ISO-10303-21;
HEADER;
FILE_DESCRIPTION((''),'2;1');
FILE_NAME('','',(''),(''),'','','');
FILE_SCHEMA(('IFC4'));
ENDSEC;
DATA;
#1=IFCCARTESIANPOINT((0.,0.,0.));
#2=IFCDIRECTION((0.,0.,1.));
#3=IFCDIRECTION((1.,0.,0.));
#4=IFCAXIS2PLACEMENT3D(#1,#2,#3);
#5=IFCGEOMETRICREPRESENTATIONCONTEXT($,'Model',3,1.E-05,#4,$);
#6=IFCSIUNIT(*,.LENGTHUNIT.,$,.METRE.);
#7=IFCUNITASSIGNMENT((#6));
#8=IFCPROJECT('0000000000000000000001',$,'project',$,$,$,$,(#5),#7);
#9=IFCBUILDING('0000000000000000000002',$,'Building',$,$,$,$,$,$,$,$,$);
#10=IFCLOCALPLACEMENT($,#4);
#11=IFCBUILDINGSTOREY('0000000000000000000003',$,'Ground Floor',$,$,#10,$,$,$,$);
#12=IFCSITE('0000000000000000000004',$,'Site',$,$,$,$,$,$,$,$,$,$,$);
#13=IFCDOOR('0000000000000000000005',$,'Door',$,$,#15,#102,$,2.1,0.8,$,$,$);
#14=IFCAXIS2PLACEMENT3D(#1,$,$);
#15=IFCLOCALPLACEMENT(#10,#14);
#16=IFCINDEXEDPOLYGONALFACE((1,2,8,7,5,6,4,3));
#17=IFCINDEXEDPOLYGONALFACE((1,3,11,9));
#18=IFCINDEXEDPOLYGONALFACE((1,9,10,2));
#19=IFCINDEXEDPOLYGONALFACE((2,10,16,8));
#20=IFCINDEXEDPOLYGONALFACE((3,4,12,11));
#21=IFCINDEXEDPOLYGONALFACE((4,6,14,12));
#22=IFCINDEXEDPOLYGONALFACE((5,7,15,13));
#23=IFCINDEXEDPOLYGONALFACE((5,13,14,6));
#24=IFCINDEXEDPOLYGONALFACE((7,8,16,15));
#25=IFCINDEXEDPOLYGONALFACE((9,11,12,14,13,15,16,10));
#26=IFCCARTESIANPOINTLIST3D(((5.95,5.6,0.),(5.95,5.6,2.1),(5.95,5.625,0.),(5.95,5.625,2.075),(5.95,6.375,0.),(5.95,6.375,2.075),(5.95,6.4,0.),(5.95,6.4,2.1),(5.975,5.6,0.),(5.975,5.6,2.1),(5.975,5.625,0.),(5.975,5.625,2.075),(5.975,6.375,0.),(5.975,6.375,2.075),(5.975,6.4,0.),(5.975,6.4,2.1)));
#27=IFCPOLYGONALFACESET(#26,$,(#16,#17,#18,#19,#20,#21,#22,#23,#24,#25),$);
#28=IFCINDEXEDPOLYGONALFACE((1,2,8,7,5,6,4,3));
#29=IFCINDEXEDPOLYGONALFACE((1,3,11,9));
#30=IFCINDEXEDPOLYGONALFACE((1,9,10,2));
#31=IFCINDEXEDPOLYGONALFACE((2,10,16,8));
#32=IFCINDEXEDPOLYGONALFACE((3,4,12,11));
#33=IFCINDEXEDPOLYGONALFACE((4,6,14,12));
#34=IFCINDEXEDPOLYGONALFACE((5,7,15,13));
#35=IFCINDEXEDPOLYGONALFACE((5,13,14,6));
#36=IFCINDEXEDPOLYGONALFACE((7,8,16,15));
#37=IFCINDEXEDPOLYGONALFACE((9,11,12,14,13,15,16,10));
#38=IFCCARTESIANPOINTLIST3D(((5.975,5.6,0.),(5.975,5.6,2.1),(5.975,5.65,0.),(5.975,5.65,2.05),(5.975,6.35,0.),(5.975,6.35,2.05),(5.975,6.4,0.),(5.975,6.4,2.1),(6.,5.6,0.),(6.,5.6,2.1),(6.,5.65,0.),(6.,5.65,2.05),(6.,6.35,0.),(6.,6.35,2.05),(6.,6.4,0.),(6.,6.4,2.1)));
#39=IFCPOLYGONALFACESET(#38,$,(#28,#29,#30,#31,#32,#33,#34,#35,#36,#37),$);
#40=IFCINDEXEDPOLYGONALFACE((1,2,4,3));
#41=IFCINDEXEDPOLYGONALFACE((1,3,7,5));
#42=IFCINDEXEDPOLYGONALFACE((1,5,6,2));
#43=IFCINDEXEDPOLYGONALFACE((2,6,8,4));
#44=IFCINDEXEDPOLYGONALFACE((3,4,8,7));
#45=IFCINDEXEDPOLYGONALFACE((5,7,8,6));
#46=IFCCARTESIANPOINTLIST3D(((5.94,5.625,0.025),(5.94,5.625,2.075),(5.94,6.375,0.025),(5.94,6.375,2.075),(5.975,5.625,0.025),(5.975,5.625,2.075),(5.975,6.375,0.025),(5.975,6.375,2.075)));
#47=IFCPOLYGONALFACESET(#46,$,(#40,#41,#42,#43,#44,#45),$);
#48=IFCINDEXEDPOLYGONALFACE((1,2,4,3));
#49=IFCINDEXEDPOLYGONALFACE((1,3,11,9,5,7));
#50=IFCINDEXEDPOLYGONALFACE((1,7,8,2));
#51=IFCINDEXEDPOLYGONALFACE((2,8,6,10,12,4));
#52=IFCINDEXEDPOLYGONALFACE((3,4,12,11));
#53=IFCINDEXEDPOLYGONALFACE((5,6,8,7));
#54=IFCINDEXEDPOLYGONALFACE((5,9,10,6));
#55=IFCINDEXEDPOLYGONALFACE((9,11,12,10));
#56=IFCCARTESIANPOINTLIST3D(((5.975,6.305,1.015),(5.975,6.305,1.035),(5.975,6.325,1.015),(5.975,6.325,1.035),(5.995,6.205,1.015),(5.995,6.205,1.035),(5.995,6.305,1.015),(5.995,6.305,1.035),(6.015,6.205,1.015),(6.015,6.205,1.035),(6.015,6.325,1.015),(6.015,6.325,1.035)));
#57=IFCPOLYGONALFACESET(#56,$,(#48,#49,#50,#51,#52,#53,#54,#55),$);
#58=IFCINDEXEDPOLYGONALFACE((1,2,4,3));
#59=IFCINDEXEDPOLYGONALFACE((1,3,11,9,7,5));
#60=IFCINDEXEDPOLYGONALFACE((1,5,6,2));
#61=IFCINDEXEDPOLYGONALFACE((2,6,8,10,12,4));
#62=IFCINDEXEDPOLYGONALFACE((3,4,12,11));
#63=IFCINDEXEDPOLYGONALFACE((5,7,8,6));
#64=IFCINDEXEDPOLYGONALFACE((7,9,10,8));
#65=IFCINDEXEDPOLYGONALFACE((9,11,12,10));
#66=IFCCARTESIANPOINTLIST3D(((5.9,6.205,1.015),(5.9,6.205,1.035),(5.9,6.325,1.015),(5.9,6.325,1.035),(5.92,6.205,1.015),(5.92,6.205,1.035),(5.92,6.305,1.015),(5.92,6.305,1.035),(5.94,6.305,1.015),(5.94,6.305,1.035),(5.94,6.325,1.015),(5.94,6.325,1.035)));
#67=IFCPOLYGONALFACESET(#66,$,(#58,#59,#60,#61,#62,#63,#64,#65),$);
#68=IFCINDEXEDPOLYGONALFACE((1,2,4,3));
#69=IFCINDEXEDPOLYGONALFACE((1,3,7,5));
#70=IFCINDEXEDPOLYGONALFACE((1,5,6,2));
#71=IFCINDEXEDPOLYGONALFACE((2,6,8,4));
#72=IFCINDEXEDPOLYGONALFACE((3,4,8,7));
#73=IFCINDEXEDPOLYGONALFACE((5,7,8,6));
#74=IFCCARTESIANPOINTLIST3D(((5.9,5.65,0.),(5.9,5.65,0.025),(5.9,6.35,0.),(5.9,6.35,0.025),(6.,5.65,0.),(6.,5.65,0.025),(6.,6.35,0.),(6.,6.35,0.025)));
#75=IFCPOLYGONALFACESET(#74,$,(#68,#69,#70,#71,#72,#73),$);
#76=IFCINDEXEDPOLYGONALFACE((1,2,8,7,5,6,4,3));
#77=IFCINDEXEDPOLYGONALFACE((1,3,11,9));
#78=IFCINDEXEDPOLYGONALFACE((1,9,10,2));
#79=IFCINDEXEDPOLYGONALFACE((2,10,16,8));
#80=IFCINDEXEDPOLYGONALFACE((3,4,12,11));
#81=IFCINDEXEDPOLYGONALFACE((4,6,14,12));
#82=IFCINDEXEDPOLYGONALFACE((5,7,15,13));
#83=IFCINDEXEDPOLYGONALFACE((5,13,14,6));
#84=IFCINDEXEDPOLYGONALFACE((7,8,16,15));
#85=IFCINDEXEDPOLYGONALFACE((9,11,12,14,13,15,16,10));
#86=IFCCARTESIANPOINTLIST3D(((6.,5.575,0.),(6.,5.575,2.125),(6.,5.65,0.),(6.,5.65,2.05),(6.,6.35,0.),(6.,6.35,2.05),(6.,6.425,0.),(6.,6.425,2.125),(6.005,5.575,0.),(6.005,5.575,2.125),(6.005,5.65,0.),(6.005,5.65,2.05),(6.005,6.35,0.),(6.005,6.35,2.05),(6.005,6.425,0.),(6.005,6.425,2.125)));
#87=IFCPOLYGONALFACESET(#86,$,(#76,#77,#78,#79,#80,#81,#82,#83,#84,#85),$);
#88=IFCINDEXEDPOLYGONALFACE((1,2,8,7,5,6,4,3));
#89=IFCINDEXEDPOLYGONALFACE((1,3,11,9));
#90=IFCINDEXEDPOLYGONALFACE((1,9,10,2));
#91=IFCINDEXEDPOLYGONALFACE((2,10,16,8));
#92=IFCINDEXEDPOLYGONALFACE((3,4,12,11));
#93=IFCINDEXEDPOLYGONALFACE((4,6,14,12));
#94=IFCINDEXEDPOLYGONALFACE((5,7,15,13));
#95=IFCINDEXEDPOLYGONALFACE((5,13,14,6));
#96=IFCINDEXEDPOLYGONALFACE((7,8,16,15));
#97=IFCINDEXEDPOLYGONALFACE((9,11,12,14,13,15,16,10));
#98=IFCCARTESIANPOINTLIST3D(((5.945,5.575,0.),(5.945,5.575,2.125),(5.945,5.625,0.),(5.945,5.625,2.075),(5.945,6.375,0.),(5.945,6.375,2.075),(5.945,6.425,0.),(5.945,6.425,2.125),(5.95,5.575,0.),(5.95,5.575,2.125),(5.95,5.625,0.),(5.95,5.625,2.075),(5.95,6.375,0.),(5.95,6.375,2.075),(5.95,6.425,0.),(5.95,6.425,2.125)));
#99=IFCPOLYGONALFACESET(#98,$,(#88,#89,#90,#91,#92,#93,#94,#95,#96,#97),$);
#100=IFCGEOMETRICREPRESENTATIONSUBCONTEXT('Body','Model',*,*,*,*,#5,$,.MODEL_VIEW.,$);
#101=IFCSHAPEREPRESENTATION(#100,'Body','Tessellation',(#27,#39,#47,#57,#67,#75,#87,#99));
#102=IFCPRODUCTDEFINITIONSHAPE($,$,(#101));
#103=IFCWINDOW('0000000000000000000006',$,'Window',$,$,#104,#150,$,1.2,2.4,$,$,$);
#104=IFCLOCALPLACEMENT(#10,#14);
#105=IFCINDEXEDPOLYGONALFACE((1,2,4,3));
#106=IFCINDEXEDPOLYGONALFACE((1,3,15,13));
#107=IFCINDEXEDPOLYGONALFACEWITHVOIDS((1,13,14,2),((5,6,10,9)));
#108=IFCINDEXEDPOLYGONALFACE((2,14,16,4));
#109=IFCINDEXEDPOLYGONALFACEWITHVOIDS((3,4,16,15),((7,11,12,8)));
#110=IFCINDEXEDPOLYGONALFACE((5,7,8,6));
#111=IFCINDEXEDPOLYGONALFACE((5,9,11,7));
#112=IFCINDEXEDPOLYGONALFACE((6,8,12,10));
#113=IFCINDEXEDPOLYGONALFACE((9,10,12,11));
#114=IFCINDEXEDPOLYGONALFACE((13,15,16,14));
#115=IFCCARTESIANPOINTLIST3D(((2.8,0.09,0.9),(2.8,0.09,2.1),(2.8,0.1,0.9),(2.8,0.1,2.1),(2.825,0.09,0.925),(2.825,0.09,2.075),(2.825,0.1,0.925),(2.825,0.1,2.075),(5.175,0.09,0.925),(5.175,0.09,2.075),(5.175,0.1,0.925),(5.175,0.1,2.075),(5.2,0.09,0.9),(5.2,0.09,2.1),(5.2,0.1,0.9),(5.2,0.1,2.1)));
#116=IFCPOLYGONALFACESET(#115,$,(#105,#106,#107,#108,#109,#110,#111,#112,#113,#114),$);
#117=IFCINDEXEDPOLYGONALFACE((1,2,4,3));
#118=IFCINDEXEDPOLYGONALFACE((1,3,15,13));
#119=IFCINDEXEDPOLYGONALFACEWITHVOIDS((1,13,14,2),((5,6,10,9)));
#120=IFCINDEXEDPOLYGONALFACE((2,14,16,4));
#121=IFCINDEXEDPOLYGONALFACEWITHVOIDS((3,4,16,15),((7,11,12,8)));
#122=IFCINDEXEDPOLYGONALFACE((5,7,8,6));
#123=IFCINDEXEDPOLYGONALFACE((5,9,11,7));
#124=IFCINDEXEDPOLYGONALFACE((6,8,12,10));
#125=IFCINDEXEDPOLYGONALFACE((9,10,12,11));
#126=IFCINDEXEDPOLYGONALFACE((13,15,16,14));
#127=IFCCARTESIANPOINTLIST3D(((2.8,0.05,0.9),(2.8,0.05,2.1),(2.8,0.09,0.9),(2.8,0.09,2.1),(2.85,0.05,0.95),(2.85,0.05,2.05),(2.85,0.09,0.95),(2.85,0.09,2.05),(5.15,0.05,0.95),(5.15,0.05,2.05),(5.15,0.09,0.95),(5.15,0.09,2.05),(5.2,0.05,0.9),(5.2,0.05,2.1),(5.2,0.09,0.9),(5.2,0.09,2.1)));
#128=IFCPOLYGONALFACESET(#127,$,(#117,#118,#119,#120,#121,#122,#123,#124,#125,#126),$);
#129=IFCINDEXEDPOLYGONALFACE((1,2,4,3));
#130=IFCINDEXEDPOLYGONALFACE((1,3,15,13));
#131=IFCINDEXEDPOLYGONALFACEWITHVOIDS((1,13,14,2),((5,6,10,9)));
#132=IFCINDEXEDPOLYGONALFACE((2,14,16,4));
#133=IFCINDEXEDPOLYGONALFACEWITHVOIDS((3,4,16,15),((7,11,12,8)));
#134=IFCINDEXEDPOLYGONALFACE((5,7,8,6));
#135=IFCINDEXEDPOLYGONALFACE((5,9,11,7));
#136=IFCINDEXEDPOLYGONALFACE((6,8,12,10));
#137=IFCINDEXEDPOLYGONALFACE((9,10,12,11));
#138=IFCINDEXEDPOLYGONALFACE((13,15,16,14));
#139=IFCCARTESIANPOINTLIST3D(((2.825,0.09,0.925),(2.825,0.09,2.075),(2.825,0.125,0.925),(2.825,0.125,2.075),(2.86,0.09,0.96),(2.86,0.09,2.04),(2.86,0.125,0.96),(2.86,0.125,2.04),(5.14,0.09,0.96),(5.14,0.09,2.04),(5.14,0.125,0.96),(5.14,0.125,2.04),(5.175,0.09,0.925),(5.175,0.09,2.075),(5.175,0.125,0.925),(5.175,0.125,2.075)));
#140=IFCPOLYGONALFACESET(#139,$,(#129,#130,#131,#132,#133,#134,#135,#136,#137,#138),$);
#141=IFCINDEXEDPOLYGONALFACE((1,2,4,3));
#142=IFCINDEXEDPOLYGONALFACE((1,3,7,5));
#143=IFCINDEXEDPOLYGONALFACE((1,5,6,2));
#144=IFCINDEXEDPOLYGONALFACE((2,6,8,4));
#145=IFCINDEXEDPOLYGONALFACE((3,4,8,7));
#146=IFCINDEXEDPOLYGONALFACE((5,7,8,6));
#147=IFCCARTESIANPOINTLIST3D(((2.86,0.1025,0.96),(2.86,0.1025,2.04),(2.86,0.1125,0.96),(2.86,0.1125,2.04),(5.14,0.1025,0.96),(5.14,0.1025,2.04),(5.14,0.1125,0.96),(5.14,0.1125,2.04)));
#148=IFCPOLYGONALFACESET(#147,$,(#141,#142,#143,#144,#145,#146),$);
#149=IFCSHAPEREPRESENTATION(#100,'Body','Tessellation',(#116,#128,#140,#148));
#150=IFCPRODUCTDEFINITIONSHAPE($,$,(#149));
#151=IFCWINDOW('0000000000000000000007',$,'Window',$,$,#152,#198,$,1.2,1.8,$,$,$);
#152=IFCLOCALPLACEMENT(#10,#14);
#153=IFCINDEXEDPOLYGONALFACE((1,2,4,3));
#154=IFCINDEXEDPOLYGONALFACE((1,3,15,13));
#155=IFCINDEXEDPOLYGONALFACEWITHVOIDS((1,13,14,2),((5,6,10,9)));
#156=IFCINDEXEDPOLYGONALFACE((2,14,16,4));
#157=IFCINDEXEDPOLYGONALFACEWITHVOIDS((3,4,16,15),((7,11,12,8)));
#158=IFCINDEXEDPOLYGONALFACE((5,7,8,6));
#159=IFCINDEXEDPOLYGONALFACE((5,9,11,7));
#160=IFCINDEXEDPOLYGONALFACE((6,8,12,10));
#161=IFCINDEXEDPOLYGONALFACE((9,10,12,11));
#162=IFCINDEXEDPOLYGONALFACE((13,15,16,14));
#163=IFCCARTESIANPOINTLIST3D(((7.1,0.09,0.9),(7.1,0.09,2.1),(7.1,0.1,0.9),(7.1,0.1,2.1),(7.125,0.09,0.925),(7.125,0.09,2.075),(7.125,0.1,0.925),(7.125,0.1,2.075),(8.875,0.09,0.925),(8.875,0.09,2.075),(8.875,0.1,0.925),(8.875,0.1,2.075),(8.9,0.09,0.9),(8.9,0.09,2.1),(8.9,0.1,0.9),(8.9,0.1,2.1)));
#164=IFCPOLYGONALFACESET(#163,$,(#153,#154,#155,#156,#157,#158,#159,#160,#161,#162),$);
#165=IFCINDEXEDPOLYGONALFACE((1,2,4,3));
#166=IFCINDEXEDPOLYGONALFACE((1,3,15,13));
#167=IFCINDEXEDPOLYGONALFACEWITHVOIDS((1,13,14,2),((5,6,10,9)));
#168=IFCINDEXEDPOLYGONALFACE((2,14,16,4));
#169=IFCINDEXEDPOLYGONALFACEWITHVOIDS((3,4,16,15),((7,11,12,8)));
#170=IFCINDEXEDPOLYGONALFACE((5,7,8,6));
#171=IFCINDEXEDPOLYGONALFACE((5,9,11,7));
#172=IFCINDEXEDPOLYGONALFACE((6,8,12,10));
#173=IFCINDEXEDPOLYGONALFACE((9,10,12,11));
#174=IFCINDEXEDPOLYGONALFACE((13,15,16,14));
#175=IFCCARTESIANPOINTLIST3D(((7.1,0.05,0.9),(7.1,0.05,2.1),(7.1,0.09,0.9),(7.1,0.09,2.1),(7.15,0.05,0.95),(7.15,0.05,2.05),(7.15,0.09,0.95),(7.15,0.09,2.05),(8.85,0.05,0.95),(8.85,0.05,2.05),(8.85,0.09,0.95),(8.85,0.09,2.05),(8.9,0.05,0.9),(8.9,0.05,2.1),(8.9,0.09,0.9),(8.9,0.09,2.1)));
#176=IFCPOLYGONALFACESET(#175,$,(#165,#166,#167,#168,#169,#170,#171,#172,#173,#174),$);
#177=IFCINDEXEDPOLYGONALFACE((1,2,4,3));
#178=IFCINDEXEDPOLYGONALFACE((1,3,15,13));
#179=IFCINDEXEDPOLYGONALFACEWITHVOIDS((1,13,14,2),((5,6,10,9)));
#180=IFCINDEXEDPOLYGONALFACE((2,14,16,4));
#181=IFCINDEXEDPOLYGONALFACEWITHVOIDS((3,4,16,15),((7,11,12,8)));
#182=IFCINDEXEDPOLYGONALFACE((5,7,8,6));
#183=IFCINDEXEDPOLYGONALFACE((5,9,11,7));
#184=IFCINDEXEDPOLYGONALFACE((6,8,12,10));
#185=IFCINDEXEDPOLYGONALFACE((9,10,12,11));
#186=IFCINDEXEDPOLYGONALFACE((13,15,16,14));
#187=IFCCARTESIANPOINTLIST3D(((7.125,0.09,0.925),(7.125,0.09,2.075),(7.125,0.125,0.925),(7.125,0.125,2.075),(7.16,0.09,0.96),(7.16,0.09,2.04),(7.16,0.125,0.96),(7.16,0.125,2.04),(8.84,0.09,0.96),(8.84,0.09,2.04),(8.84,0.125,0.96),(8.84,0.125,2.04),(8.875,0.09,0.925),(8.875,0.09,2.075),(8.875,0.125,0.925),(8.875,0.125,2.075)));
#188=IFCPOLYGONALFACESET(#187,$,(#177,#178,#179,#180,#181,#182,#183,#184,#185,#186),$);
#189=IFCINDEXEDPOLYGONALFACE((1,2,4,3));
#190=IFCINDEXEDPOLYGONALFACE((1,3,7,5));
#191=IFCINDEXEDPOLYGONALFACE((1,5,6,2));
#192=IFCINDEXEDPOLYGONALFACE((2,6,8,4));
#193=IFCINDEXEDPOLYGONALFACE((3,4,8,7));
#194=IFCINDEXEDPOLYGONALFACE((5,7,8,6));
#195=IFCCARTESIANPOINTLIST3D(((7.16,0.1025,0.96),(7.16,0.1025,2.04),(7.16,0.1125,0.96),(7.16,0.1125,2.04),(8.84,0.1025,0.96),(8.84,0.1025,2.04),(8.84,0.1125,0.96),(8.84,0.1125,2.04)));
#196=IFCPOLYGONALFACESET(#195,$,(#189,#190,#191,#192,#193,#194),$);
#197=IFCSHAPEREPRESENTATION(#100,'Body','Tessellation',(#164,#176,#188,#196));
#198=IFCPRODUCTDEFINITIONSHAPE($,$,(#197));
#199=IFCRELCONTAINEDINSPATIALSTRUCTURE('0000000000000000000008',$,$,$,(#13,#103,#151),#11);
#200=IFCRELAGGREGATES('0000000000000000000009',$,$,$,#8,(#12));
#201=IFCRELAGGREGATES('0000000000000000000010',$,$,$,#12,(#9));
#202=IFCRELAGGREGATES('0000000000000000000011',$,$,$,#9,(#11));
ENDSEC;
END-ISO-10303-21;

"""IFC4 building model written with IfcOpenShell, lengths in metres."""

from ifc_helpers import new_model, si_unit, frame, origin_with_axes, place, context, subcontext, project, spatial, line, indexed_curve, outline, extrude, element, save


model = new_model("IFC4")

# Units and contexts
model_context = context("Model", 3, precision=1e-05, world=origin_with_axes())
body_context = subcontext(model_context, "Body", "Model", "MODEL_VIEW")
ifc_project = project(units=[si_unit("LENGTHUNIT", "METRE")], contexts=[model_context])

# Site, building, storey
site = spatial("IfcSite", under=ifc_project, Name="Site")
building = spatial("IfcBuilding", under=site, Name="Building")
storey_placement = place(None, origin_with_axes())
storey = spatial("IfcBuildingStorey", under=building, at=storey_placement, Name="Ground Floor")

# Door
door_1_placement = place(storey_placement, frame((6.0, 5.6, 0.0), z_axis=(0.0, 0.0, 1.0), x_axis=(0.0, 1.0, 0.0)))
element("IfcDoor", 1, at=door_1_placement, inside=storey, Name="Door", OverallHeight=2.1, OverallWidth=0.8, context=body_context, shape_type="SweptSolid", body=[
    extrude(outline(indexed_curve([(0.0, 0.0), (0.0, 2.1), (0.8, 2.1), (0.8, 0.0), (0.775, 0.0), (0.775, 2.075), (0.025, 2.075), (0.025, 0.0)], segments=[line(1, 2, 3, 4, 5, 6, 7, 8, 1)])), frame((0.0, 0.025, 0.0), z_axis=(0.0, -1.0, 0.0), x_axis=(1.0, 0.0, 0.0)), (0.0, 0.0, -1.0), 0.025),
    extrude(outline(indexed_curve([(0.0, 0.0), (0.0, 2.1), (0.8, 2.1), (0.8, 0.0), (0.75, 0.0), (0.75, 2.05), (0.05, 2.05), (0.05, 0.0)], segments=[line(1, 2, 3, 4, 5, 6, 7, 8, 1)])), frame((0.0, 0.0, 0.0), z_axis=(0.0, -1.0, 0.0), x_axis=(1.0, 0.0, 0.0)), (0.0, 0.0, -1.0), 0.025),
    extrude(outline(indexed_curve([(0.0, 0.0), (0.75, 0.0), (0.75, 0.035), (0.0, 0.035)], segments=[line(1, 2, 3, 4, 1)])), frame((0.025, 0.025, 0.025), z_axis=(0.0, 0.0, 1.0), x_axis=(1.0, 0.0, 0.0)), (0.0, 0.0, 1.0), 2.05),
    extrude(outline(indexed_curve([(0.0, 0.0), (0.0, -0.04), (-0.12, -0.04), (-0.12, -0.02), (-0.02, -0.02), (-0.02, 0.0)], segments=[line(1, 2, 3, 4, 5, 6, 1)])), frame((0.725, 0.025, 1.015), z_axis=(0.0, 0.0, 1.0), x_axis=(1.0, 0.0, 0.0)), (0.0, 0.0, 1.0), 0.02),
    extrude(outline(indexed_curve([(0.0, 0.0), (0.0, 0.04), (-0.12, 0.04), (-0.12, 0.02), (-0.02, 0.02), (-0.02, 0.0)], segments=[line(1, 2, 3, 4, 5, 6, 1)])), frame((0.725, 0.06, 1.015), z_axis=(0.0, 0.0, 1.0), x_axis=(1.0, 0.0, 0.0)), (0.0, 0.0, 1.0), 0.02),
    extrude(outline(indexed_curve([(0.0, 0.0), (0.7, 0.0), (0.7, 0.1), (0.0, 0.1)], segments=[line(1, 2, 3, 4, 1)])), frame((0.05, 0.0, 0.0), z_axis=(0.0, 0.0, 1.0), x_axis=(1.0, 0.0, 0.0)), (0.0, 0.0, 1.0), 0.025),
    extrude(outline(indexed_curve([(0.0, 0.0), (0.0, 2.125), (0.85, 2.125), (0.85, 0.0), (0.775, 0.0), (0.775, 2.05), (0.075, 2.05), (0.075, 0.0)], segments=[line(1, 2, 3, 4, 5, 6, 7, 8, 1)])), frame((-0.025, -0.005, 0.0), z_axis=(0.0, -1.0, 0.0), x_axis=(1.0, 0.0, 0.0)), (0.0, 0.0, -1.0), 0.005),
    extrude(outline(indexed_curve([(0.0, 0.0), (0.0, 2.125), (0.85, 2.125), (0.85, 0.0), (0.8, 0.0), (0.8, 2.075), (0.05, 2.075), (0.05, 0.0)], segments=[line(1, 2, 3, 4, 5, 6, 7, 8, 1)])), frame((-0.025, 0.05, 0.0), z_axis=(0.0, -1.0, 0.0), x_axis=(1.0, 0.0, 0.0)), (0.0, 0.0, -1.0), 0.005),
])

# Windows
window_1_placement = place(storey_placement, frame((2.8, 0.0, 0.9), z_axis=(0.0, 0.0, 1.0), x_axis=(1.0, 0.0, 0.0)))
element("IfcWindow", 2, at=window_1_placement, inside=storey, Name="Window", OverallHeight=1.2, OverallWidth=2.4, context=body_context, shape_type="SweptSolid", body=[
    extrude(outline(indexed_curve([(0.0, 0.0), (2.4, 0.0), (2.4, 1.2), (0.0, 1.2)], segments=[line(1, 2, 3, 4, 1)]), holes=[indexed_curve([(0.025, 0.025), (2.375, 0.025), (2.375, 1.175), (0.025, 1.175)], segments=[line(1, 2, 3, 4, 1)])]), frame((0.0, 0.09, 0.0), z_axis=(0.0, -1.0, 0.0), x_axis=(1.0, 0.0, 0.0)), (0.0, 0.0, -1.0), 0.01),
    extrude(outline(indexed_curve([(0.0, 0.0), (2.4, 0.0), (2.4, 1.2), (0.0, 1.2)], segments=[line(1, 2, 3, 4, 1)]), holes=[indexed_curve([(0.05, 0.05), (2.35, 0.05), (2.35, 1.15), (0.05, 1.15)], segments=[line(1, 2, 3, 4, 1)])]), frame((0.0, 0.05, 0.0), z_axis=(0.0, -1.0, 0.0), x_axis=(1.0, 0.0, 0.0)), (0.0, 0.0, -1.0), 0.04),
    extrude(outline(indexed_curve([(0.0, 0.0), (2.35, 0.0), (2.35, 1.15), (0.0, 1.15)], segments=[line(1, 2, 3, 4, 1)]), holes=[indexed_curve([(0.035, 0.035), (2.315, 0.035), (2.315, 1.115), (0.035, 1.115)], segments=[line(1, 2, 3, 4, 1)])]), frame((0.025, 0.09, 0.025), z_axis=(0.0, -1.0, 0.0), x_axis=(1.0, 0.0, 0.0)), (0.0, 0.0, -1.0), 0.035),
    extrude(outline(indexed_curve([(0.035, 0.035), (2.315, 0.035), (2.315, 1.115), (0.035, 1.115)], segments=[line(1, 2, 3, 4, 1)])), frame((0.025, 0.1025, 0.025), z_axis=(0.0, -1.0, 0.0), x_axis=(1.0, 0.0, 0.0)), (0.0, 0.0, -1.0), 0.01),
])
window_2_placement = place(storey_placement, frame((7.1, 0.0, 0.9), z_axis=(0.0, 0.0, 1.0), x_axis=(1.0, 0.0, 0.0)))
element("IfcWindow", 3, at=window_2_placement, inside=storey, Name="Window", OverallHeight=1.2, OverallWidth=1.8, context=body_context, shape_type="SweptSolid", body=[
    extrude(outline(indexed_curve([(0.0, 0.0), (1.8, 0.0), (1.8, 1.2), (0.0, 1.2)], segments=[line(1, 2, 3, 4, 1)]), holes=[indexed_curve([(0.025, 0.025), (1.775, 0.025), (1.775, 1.175), (0.025, 1.175)], segments=[line(1, 2, 3, 4, 1)])]), frame((0.0, 0.09, 0.0), z_axis=(0.0, -1.0, 0.0), x_axis=(1.0, 0.0, 0.0)), (0.0, 0.0, -1.0), 0.01),
    extrude(outline(indexed_curve([(0.0, 0.0), (1.8, 0.0), (1.8, 1.2), (0.0, 1.2)], segments=[line(1, 2, 3, 4, 1)]), holes=[indexed_curve([(0.05, 0.05), (1.75, 0.05), (1.75, 1.15), (0.05, 1.15)], segments=[line(1, 2, 3, 4, 1)])]), frame((0.0, 0.05, 0.0), z_axis=(0.0, -1.0, 0.0), x_axis=(1.0, 0.0, 0.0)), (0.0, 0.0, -1.0), 0.04),
    extrude(outline(indexed_curve([(0.0, 0.0), (1.75, 0.0), (1.75, 1.15), (0.0, 1.15)], segments=[line(1, 2, 3, 4, 1)]), holes=[indexed_curve([(0.035, 0.035), (1.715, 0.035), (1.715, 1.115), (0.035, 1.115)], segments=[line(1, 2, 3, 4, 1)])]), frame((0.025, 0.09, 0.025), z_axis=(0.0, -1.0, 0.0), x_axis=(1.0, 0.0, 0.0)), (0.0, 0.0, -1.0), 0.035),
    extrude(outline(indexed_curve([(0.035, 0.035), (1.715, 0.035), (1.715, 1.115), (0.035, 1.115)], segments=[line(1, 2, 3, 4, 1)])), frame((0.025, 0.1025, 0.025), z_axis=(0.0, -1.0, 0.0), x_axis=(1.0, 0.0, 0.0)), (0.0, 0.0, -1.0), 0.01),
])

save(model, "model.ifc")
